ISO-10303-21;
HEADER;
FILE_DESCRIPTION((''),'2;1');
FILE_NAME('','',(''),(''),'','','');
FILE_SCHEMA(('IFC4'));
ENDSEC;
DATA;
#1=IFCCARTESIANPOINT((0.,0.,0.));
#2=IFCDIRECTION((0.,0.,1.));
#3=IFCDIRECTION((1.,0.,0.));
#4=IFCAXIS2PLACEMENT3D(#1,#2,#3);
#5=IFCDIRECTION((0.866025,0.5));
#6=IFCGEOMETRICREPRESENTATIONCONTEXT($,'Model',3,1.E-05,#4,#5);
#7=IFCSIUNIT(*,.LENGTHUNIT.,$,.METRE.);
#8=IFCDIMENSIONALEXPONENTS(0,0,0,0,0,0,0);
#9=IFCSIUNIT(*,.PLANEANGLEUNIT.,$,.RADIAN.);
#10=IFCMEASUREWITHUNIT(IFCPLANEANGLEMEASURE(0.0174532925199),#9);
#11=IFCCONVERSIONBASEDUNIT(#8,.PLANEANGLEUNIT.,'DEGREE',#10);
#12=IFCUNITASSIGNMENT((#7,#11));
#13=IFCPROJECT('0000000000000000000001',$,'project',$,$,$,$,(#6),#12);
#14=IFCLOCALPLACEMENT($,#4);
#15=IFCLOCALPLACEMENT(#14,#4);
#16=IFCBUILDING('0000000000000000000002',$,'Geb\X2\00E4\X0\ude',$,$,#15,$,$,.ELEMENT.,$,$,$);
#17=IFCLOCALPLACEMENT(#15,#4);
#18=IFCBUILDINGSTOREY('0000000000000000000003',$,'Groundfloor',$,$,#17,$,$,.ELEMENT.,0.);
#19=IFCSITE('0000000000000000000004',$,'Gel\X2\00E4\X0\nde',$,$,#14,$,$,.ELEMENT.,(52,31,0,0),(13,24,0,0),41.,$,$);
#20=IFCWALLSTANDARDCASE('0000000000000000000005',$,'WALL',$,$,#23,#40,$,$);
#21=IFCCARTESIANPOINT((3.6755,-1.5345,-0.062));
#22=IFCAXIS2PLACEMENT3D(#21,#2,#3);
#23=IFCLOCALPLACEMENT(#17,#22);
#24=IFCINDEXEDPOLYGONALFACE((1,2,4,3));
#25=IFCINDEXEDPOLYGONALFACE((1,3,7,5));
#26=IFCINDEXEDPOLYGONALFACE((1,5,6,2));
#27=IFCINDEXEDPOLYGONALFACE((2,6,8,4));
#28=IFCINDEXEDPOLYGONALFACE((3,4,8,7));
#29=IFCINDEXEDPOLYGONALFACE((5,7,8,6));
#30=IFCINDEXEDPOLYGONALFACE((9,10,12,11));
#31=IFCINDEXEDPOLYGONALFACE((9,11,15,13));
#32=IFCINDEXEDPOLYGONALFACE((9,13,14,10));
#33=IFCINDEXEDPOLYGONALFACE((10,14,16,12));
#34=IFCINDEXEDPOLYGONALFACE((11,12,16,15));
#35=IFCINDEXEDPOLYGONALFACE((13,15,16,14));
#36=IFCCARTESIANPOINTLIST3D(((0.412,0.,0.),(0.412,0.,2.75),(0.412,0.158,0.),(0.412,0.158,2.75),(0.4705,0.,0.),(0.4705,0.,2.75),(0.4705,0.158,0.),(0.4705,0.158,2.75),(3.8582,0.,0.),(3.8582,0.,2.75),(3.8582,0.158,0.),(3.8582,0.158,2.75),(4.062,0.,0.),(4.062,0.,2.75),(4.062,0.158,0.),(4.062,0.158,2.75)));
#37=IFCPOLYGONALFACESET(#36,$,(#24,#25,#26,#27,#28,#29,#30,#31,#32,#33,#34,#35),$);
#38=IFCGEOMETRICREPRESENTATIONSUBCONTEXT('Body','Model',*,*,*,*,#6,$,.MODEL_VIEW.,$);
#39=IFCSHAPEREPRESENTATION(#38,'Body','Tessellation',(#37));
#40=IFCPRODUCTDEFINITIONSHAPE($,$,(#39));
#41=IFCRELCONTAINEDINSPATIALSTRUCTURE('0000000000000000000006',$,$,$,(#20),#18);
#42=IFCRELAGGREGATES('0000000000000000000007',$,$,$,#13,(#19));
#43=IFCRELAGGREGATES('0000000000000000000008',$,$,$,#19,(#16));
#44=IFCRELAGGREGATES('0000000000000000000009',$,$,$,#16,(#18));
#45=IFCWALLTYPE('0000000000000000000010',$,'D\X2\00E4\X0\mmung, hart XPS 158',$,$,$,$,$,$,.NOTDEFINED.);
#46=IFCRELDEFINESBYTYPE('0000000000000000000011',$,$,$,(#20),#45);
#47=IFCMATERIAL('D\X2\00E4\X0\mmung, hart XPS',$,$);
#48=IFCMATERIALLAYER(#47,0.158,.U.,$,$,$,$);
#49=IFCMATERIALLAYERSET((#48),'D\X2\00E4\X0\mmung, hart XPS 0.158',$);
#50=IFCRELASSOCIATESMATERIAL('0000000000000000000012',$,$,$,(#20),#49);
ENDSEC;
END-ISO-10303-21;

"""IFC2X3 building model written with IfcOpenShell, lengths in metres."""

from ifc_helpers import new_model, entity, si_unit, converted_unit, direction, frame, origin_with_axes, origin_2d_with_axis, place, context, subcontext, project, spatial, polyline, rectangle, outline, extrude, material, layer, layer_set, layer_usage, type_object, element, save


model = new_model("IFC2X3")

# Units and contexts
model_context = context("Model", 3, precision=1e-05, world=origin_with_axes(), true_north=direction((0.866025, 0.5)))
body_context = subcontext(model_context, "Body", "Model", "MODEL_VIEW")
ifc_project = project(units=[si_unit("LENGTHUNIT", "METRE"), converted_unit("PLANEANGLEUNIT", "DEGREE", entity("IfcPlaneAngleMeasure", 0.0174532925199), si_unit("PLANEANGLEUNIT", "RADIAN"), dimensions=[0, 0, 0, 0, 0, 0, 0])], contexts=[model_context])

# Site, building, storey
site_placement = place(None, origin_with_axes())
site = spatial("IfcSite", under=ifc_project, at=site_placement, Name="Gelände", CompositionType="ELEMENT", RefLatitude=(52, 31, 0, 0), RefLongitude=(13, 24, 0, 0), RefElevation=41.0)
building_placement = place(site_placement, origin_with_axes())
building = spatial("IfcBuilding", under=site, at=building_placement, Name="Gebäude", CompositionType="ELEMENT")
storey_placement = place(building_placement, origin_with_axes())
storey = spatial("IfcBuildingStorey", under=building, at=storey_placement, Name="Groundfloor", CompositionType="ELEMENT", Elevation=0.0)

# Wall, opening
ifc_material_1 = material(Name="Dämmung, hart XPS")
ifc_layer_1 = layer(ifc_material_1, 0.158, ventilated="UNKNOWN")
ifc_layer_set_1 = layer_set([ifc_layer_1], Name="Dämmung, hart XPS 0.158")
ifc_layer_usage_1 = layer_usage(ifc_layer_set_1, "AXIS2", "NEGATIVE", 0.158)
wall_type_1 = type_object("IfcWallType", Name="Dämmung, hart XPS 158", PredefinedType="NOTDEFINED")
wall_1_placement = place(storey_placement, frame((3.6755, -1.5345, -0.062), z_axis=(0.0, 0.0, 1.0), x_axis=(1.0, 0.0, 0.0)))
wall_1 = element("IfcWallStandardCase", 1, at=wall_1_placement, inside=storey, type_object=wall_type_1, material=ifc_layer_usage_1, Name="WALL", context=body_context, shape_type="SweptSolid", body=[
    extrude(outline(polyline([(0.412, 0.0), (4.062, 0.0), (4.062, 0.158), (0.412, 0.158), (0.412, 0.0)])), origin_with_axes(), (0.0, 0.0, 1.0), 2.75),
])
opening_1_placement = place(wall_1_placement, frame((2.1643, 0.0, 0.0), z_axis=(0.0, 0.0, 1.0), x_axis=(1.0, 0.0, 0.0)))
element("IfcOpeningElement", 2, at=opening_1_placement, cuts=wall_1, context=body_context, shape_type="SweptSolid", body=[
    extrude(rectangle(XDim=3.3877, YDim=2.75, at=origin_2d_with_axis()), frame((0.0, -0.158, 1.375), z_axis=(0.0, -1.0, 0.0), x_axis=(1.0, 0.0, 0.0)), (0.0, 0.0, -1.0), 0.474),
])

save(model, "model.ifc")
